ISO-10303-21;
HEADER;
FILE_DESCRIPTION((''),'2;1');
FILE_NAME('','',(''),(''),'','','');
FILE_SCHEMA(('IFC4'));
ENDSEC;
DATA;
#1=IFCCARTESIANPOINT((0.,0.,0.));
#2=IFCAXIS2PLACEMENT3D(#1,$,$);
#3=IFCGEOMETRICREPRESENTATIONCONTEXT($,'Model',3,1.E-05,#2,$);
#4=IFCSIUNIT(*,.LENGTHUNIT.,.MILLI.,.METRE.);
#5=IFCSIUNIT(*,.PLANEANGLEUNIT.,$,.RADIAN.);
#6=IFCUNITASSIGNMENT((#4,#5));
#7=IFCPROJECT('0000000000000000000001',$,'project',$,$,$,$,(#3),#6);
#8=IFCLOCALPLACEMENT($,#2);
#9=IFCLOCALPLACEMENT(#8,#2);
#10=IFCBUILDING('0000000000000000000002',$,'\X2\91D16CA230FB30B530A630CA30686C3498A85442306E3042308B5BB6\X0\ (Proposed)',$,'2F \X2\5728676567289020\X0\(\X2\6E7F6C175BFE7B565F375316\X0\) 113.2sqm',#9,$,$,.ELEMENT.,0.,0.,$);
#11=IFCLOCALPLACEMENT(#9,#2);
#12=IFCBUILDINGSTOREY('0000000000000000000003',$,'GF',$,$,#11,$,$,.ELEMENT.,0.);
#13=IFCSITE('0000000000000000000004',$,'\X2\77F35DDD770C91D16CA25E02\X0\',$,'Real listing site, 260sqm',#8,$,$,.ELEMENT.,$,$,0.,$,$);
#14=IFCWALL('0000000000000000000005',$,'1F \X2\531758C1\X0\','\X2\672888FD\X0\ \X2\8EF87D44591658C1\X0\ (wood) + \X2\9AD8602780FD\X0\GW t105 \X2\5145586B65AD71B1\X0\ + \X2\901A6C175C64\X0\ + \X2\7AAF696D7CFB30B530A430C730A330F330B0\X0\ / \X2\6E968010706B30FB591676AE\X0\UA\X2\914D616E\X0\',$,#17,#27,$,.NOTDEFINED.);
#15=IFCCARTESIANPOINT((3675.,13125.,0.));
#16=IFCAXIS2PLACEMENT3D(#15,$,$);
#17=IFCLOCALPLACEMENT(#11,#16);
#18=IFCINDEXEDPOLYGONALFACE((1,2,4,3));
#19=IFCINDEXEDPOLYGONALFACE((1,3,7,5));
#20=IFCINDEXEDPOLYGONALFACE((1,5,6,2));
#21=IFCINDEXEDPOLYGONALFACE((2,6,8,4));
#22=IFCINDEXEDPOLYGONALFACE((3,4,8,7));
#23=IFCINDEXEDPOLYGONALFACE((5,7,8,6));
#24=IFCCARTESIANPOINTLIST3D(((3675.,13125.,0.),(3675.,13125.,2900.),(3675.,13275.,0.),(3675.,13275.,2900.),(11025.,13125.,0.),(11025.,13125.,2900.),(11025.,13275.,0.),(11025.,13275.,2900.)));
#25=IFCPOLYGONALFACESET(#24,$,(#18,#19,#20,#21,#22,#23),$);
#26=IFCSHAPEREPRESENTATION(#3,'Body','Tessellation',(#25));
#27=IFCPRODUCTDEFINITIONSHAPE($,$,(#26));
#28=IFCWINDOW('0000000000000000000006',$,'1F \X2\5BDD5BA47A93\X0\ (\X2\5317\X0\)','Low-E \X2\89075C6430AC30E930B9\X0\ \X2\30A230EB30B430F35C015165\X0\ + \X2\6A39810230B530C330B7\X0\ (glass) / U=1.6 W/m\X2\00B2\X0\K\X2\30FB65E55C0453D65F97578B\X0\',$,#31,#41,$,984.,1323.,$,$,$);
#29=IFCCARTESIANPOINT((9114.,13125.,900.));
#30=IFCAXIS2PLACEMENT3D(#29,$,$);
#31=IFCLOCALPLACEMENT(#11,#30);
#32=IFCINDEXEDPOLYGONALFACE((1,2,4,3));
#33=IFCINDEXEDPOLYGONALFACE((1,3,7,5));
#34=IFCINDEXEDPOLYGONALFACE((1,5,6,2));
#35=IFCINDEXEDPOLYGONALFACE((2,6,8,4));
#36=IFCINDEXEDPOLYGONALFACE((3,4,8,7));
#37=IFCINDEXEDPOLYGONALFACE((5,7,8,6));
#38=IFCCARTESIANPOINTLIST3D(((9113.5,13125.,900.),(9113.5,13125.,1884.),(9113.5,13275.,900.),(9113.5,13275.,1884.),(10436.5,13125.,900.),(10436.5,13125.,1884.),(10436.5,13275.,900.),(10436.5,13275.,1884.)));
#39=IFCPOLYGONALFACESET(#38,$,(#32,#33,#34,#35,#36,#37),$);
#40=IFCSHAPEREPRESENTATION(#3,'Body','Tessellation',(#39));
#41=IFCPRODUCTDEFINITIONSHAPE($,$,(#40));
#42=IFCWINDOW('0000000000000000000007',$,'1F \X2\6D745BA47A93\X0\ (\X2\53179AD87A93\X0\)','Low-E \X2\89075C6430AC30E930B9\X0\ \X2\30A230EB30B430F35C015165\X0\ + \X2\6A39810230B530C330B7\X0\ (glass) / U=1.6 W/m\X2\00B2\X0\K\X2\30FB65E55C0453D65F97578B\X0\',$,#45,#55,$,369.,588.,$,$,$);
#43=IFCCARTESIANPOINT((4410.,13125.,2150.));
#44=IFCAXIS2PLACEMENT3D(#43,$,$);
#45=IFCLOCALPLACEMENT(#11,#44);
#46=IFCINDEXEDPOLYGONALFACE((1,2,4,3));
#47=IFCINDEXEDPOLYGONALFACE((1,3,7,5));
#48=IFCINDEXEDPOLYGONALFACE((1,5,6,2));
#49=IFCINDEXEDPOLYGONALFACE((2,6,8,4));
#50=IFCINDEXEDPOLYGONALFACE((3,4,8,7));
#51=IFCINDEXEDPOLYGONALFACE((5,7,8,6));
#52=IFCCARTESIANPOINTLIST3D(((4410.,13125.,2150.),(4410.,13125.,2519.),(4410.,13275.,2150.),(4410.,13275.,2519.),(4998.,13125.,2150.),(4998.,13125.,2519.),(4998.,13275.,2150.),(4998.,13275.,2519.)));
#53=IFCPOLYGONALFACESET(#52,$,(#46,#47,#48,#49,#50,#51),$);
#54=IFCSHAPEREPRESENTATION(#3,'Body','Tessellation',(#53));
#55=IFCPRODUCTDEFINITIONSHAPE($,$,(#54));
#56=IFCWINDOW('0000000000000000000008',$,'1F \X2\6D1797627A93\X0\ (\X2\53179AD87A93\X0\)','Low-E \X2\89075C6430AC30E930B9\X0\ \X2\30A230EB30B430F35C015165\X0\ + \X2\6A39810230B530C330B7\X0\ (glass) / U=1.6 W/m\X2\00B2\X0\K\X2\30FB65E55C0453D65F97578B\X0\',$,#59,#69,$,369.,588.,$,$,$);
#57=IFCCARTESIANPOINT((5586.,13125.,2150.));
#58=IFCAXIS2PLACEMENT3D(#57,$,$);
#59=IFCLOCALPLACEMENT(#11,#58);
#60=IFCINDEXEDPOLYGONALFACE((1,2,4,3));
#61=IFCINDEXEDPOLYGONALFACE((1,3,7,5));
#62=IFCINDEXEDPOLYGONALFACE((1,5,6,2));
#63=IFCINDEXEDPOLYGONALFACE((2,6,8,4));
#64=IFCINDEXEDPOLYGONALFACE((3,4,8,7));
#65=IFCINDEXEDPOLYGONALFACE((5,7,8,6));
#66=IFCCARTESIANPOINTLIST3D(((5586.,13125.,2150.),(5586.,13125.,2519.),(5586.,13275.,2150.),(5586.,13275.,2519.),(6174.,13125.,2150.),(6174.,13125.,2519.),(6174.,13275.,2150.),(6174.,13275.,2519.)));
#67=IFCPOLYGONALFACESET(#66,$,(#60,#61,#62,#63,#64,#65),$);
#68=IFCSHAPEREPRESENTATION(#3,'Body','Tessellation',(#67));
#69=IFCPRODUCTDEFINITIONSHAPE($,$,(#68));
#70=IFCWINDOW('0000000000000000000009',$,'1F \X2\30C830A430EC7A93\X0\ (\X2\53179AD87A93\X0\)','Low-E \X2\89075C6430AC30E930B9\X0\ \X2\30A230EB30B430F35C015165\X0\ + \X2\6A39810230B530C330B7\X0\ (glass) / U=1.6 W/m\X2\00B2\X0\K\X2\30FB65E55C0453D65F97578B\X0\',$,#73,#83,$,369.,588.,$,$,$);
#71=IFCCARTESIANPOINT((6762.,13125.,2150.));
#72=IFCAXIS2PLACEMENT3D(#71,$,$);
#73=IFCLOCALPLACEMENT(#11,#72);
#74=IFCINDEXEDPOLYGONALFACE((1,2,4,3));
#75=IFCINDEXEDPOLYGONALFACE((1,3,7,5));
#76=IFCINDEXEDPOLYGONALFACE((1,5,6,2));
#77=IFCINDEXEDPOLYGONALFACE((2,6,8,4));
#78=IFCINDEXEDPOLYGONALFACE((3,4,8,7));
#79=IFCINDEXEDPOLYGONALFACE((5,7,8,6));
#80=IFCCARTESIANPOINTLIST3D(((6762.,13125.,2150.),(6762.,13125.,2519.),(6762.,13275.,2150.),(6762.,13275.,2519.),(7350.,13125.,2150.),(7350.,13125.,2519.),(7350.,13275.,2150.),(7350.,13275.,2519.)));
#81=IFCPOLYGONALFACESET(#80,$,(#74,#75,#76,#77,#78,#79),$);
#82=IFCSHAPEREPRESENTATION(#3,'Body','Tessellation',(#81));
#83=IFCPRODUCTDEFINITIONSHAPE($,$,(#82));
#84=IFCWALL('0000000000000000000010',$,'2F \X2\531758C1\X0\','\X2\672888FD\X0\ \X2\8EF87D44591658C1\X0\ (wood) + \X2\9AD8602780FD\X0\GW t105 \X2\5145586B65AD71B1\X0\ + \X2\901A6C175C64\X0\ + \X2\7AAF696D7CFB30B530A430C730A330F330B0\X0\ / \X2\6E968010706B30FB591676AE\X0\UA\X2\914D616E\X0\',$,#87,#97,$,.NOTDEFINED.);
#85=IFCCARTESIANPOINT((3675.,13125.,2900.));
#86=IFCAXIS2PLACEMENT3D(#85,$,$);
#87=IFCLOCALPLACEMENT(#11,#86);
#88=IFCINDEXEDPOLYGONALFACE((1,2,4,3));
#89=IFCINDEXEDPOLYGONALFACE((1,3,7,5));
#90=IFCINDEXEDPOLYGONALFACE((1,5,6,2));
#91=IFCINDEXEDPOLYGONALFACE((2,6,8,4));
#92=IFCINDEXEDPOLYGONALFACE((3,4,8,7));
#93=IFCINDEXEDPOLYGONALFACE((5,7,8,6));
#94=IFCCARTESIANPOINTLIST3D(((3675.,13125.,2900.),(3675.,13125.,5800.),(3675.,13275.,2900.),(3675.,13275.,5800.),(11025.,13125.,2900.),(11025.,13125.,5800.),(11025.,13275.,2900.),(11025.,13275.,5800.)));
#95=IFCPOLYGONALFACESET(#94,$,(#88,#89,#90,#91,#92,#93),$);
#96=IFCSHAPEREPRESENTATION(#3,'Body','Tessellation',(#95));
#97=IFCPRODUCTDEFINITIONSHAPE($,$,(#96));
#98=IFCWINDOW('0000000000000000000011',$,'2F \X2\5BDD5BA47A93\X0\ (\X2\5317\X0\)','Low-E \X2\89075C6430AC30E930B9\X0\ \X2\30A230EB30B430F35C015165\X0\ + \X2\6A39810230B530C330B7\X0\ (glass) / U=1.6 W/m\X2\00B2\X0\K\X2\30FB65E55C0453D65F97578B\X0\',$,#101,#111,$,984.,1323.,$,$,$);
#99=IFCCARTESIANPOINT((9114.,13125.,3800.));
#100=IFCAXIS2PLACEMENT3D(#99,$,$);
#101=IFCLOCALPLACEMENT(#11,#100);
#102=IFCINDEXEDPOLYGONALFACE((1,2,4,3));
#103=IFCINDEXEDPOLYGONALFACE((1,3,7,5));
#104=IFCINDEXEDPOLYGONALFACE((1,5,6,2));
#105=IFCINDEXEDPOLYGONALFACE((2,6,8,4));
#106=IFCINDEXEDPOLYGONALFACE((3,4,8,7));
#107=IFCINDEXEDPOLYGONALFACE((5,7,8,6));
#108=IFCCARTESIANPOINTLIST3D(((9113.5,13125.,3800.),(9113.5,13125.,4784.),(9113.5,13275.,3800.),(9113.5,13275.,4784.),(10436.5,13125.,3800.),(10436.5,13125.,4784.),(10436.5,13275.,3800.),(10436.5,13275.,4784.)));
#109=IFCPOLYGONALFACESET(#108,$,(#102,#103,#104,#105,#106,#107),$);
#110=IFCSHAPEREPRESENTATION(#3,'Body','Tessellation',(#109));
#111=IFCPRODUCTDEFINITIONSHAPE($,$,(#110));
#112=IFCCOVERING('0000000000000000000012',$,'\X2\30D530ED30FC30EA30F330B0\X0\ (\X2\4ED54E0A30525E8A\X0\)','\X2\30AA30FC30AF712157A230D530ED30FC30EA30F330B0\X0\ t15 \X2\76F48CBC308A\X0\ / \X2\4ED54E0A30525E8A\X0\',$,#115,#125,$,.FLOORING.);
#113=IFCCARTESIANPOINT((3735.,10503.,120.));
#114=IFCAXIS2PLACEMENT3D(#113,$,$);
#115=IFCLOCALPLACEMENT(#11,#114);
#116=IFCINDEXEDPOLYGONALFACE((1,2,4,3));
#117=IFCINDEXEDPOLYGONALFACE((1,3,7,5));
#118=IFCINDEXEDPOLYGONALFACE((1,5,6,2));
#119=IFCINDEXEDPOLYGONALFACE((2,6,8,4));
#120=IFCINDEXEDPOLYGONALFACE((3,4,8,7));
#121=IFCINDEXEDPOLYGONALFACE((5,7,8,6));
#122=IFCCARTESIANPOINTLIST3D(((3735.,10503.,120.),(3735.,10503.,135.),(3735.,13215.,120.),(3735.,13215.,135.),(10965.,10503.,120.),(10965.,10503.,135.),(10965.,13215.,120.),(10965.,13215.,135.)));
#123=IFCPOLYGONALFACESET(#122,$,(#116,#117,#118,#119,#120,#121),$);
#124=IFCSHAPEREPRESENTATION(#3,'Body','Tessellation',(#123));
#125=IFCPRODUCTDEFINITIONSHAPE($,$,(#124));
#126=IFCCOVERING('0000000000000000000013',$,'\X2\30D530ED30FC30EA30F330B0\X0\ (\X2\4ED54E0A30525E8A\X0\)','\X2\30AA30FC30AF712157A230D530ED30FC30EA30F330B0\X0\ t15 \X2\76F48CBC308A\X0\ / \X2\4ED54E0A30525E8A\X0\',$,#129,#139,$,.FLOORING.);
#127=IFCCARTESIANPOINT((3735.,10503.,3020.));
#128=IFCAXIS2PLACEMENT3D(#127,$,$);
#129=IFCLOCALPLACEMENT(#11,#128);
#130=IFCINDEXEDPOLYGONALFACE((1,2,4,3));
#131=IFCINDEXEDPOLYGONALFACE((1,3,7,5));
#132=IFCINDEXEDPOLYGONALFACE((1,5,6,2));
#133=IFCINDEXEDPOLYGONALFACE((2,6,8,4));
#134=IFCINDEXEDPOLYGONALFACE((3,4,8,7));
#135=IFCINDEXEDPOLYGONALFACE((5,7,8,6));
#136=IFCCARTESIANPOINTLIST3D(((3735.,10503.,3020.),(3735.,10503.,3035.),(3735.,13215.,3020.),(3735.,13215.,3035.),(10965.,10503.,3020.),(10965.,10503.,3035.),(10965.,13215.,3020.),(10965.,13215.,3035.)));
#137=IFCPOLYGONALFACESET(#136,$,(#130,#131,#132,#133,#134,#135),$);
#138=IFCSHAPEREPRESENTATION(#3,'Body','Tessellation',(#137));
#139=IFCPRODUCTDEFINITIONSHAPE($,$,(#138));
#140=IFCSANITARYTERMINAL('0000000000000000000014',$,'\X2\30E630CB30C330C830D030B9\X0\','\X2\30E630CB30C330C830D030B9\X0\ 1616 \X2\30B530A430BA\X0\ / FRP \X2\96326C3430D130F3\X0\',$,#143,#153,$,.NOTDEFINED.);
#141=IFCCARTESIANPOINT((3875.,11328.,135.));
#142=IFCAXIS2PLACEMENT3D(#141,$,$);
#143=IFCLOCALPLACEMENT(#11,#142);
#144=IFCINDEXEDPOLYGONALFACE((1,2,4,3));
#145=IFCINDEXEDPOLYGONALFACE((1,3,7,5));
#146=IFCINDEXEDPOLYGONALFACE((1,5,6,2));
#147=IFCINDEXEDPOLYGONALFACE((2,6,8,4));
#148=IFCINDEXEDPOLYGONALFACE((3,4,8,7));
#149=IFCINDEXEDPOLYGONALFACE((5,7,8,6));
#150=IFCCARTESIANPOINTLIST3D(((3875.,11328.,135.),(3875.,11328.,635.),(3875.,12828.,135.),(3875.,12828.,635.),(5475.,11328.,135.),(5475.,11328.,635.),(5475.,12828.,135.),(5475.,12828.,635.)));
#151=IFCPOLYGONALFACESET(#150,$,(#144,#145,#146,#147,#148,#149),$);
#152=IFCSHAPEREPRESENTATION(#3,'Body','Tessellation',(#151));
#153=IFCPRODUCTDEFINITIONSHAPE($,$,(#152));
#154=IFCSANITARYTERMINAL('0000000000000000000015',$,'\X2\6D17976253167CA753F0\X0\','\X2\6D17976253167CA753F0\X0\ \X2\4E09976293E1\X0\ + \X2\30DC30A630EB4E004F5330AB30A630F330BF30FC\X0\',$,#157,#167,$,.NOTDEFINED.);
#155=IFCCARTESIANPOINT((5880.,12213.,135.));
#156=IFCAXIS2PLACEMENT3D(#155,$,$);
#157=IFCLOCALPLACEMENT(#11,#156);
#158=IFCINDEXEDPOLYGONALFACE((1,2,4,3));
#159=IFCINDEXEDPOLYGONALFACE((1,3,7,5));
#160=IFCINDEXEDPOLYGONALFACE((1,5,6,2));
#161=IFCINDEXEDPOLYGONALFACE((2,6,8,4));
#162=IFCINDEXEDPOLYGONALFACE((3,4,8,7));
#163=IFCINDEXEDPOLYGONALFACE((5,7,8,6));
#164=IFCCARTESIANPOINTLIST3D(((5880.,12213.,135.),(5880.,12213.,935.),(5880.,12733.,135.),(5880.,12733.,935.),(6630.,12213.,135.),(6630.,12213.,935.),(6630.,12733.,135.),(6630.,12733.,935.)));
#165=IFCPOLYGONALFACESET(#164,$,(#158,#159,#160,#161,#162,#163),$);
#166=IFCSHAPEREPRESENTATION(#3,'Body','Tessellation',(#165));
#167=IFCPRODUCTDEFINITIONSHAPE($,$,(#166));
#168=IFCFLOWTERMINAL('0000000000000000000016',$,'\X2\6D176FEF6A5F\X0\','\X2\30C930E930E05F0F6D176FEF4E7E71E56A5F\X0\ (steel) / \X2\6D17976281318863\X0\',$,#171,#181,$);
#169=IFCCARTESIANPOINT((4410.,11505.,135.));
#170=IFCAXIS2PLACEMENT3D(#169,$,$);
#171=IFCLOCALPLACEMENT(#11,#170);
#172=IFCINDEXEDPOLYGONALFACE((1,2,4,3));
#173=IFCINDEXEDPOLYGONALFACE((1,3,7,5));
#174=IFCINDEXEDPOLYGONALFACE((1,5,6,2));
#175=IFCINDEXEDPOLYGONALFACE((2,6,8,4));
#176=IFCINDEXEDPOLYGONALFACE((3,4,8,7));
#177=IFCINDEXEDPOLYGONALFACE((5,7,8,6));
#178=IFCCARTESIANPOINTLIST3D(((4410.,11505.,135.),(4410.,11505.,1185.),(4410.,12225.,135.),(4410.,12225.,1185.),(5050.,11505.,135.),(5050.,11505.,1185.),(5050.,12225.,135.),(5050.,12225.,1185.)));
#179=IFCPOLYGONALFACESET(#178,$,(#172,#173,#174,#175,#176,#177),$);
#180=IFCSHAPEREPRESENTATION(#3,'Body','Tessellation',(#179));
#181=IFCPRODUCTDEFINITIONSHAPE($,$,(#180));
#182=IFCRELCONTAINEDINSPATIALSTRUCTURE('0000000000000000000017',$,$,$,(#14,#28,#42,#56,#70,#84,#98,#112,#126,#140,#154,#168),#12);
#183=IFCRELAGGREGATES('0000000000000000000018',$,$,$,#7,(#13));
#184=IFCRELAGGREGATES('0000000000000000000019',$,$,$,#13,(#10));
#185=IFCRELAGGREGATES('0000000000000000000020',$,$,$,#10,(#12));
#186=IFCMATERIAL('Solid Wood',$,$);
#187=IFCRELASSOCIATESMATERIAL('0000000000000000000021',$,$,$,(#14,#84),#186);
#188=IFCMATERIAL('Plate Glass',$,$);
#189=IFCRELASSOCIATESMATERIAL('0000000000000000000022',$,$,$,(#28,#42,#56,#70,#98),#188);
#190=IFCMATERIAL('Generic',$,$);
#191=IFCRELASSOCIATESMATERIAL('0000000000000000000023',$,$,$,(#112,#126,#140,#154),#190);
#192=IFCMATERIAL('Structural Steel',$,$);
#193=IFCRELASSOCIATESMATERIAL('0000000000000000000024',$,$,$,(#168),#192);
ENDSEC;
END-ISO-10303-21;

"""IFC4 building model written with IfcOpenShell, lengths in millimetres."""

from ifc_helpers import new_model, si_unit, frame, frame_2d, origin, place, context, project, spatial, rectangle, extrude, material, element, fill, save


model = new_model("IFC4")

# Units and contexts
model_context = context("Model", 3, precision=1e-05, world=origin())
ifc_project = project(units=[si_unit("LENGTHUNIT", "METRE", prefix="MILLI"), si_unit("PLANEANGLEUNIT", "RADIAN")], contexts=[model_context])

# Site, building, storey
site_placement = place(None, origin())
site = spatial("IfcSite", under=ifc_project, at=site_placement, Name="石川県金沢市", ObjectType="Real listing site, 260sqm", CompositionType="ELEMENT", RefElevation=0.0)
building_placement = place(site_placement, origin())
building = spatial("IfcBuilding", under=site, at=building_placement, Name="金沢・サウナと水風呂のある家 (Proposed)", ObjectType="2F 在来木造(湿気対策強化) 113.2sqm", CompositionType="ELEMENT", ElevationOfRefHeight=0.0, ElevationOfTerrain=0.0)
storey_placement = place(building_placement, origin())
storey = spatial("IfcBuildingStorey", under=building, at=storey_placement, Name="GF", CompositionType="ELEMENT", Elevation=0.0)

# Shared definitions
ifc_material_1 = material(Name="Solid Wood")

# Wall, openings, windows
wall_1_placement = place(storey_placement, frame((3675.0, 13125.0, 0.0)))
wall_1 = element("IfcWall", 1, at=wall_1_placement, inside=storey, material=ifc_material_1, Name="1F 北壁", Description="木製 軸組外壁 (wood) + 高性能GW t105 充填断熱 + 通気層 + 窯業系サイディング / 準耐火・外皮UA配慮", PredefinedType="NOTDEFINED", context=model_context, shape_type="SweptSolid", body=[
    extrude(rectangle(XDim=7350.0, YDim=150.0, at=frame_2d((3675.0, 75.0))), frame((3675.0, 13125.0, 0.0)), (0.0, 0.0, 1.0), 2900.0),
])
opening_1_placement = place(storey_placement, frame((9114.0, 13125.0, 900.0)))
opening_1 = element("IfcOpeningElement", 2, at=opening_1_placement, cuts=wall_1, PredefinedType="NOTDEFINED", context=model_context, shape_type="SweptSolid", body=[
    extrude(rectangle(XDim=1323.0, YDim=150.0, at=frame_2d((661.0, 75.0))), frame((9114.0, 13125.0, 900.0)), (0.0, 0.0, 1.0), 984.0),
])
opening_2_placement = place(storey_placement, frame((4410.0, 13125.0, 2150.0)))
opening_2 = element("IfcOpeningElement", 3, at=opening_2_placement, cuts=wall_1, PredefinedType="NOTDEFINED", context=model_context, shape_type="SweptSolid", body=[
    extrude(rectangle(XDim=588.0, YDim=150.0, at=frame_2d((294.0, 75.0))), frame((4410.0, 13125.0, 2150.0)), (0.0, 0.0, 1.0), 369.0),
])
opening_3_placement = place(storey_placement, frame((5586.0, 13125.0, 2150.0)))
opening_3 = element("IfcOpeningElement", 4, at=opening_3_placement, cuts=wall_1, PredefinedType="NOTDEFINED", context=model_context, shape_type="SweptSolid", body=[
    extrude(rectangle(XDim=588.0, YDim=150.0, at=frame_2d((294.0, 75.0))), frame((5586.0, 13125.0, 2150.0)), (0.0, 0.0, 1.0), 369.0),
])
opening_4_placement = place(storey_placement, frame((6762.0, 13125.0, 2150.0)))
opening_4 = element("IfcOpeningElement", 5, at=opening_4_placement, cuts=wall_1, PredefinedType="NOTDEFINED", context=model_context, shape_type="SweptSolid", body=[
    extrude(rectangle(XDim=588.0, YDim=150.0, at=frame_2d((294.0, 75.0))), frame((6762.0, 13125.0, 2150.0)), (0.0, 0.0, 1.0), 369.0),
])
ifc_material_2 = material(Name="Plate Glass")
window_1_placement = place(storey_placement, frame((9114.0, 13125.0, 900.0)))
window_1 = element("IfcWindow", 6, at=window_1_placement, inside=storey, material=ifc_material_2, Name="1F 寝室窓 (北)", Description="Low-E 複層ガラス アルゴン封入 + 樹脂サッシ (glass) / U=1.6 W/m²K・日射取得型", OverallHeight=984.0, OverallWidth=1323.0, context=model_context, shape_type="SweptSolid", body=[
    extrude(rectangle(XDim=1323.0, YDim=150.0, at=frame_2d((661.0, 75.0))), frame((9114.0, 13125.0, 900.0)), (0.0, 0.0, 1.0), 984.0),
])
fill(opening_1, window_1)
window_2_placement = place(storey_placement, frame((4410.0, 13125.0, 2150.0)))
window_2 = element("IfcWindow", 7, at=window_2_placement, inside=storey, material=ifc_material_2, Name="1F 浴室窓 (北高窓)", Description="Low-E 複層ガラス アルゴン封入 + 樹脂サッシ (glass) / U=1.6 W/m²K・日射取得型", OverallHeight=369.0, OverallWidth=588.0, context=model_context, shape_type="SweptSolid", body=[
    extrude(rectangle(XDim=588.0, YDim=150.0, at=frame_2d((294.0, 75.0))), frame((4410.0, 13125.0, 2150.0)), (0.0, 0.0, 1.0), 369.0),
])
fill(opening_2, window_2)
window_3_placement = place(storey_placement, frame((5586.0, 13125.0, 2150.0)))
window_3 = element("IfcWindow", 8, at=window_3_placement, inside=storey, material=ifc_material_2, Name="1F 洗面窓 (北高窓)", Description="Low-E 複層ガラス アルゴン封入 + 樹脂サッシ (glass) / U=1.6 W/m²K・日射取得型", OverallHeight=369.0, OverallWidth=588.0, context=model_context, shape_type="SweptSolid", body=[
    extrude(rectangle(XDim=588.0, YDim=150.0, at=frame_2d((294.0, 75.0))), frame((5586.0, 13125.0, 2150.0)), (0.0, 0.0, 1.0), 369.0),
])
fill(opening_3, window_3)
window_4_placement = place(storey_placement, frame((6762.0, 13125.0, 2150.0)))
window_4 = element("IfcWindow", 9, at=window_4_placement, inside=storey, material=ifc_material_2, Name="1F トイレ窓 (北高窓)", Description="Low-E 複層ガラス アルゴン封入 + 樹脂サッシ (glass) / U=1.6 W/m²K・日射取得型", OverallHeight=369.0, OverallWidth=588.0, context=model_context, shape_type="SweptSolid", body=[
    extrude(rectangle(XDim=588.0, YDim=150.0, at=frame_2d((294.0, 75.0))), frame((6762.0, 13125.0, 2150.0)), (0.0, 0.0, 1.0), 369.0),
])
fill(opening_4, window_4)

# Wall, opening, window
wall_2_placement = place(storey_placement, frame((3675.0, 13125.0, 2900.0)))
wall_2 = element("IfcWall", 10, at=wall_2_placement, inside=storey, material=ifc_material_1, Name="2F 北壁", Description="木製 軸組外壁 (wood) + 高性能GW t105 充填断熱 + 通気層 + 窯業系サイディング / 準耐火・外皮UA配慮", PredefinedType="NOTDEFINED", context=model_context, shape_type="SweptSolid", body=[
    extrude(rectangle(XDim=7350.0, YDim=150.0, at=frame_2d((3675.0, 75.0))), frame((3675.0, 13125.0, 2900.0)), (0.0, 0.0, 1.0), 2900.0),
])
opening_5_placement = place(storey_placement, frame((9114.0, 13125.0, 3800.0)))
opening_5 = element("IfcOpeningElement", 11, at=opening_5_placement, cuts=wall_2, PredefinedType="NOTDEFINED", context=model_context, shape_type="SweptSolid", body=[
    extrude(rectangle(XDim=1323.0, YDim=150.0, at=frame_2d((661.0, 75.0))), frame((9114.0, 13125.0, 3800.0)), (0.0, 0.0, 1.0), 984.0),
])
window_5_placement = place(storey_placement, frame((9114.0, 13125.0, 3800.0)))
window_5 = element("IfcWindow", 12, at=window_5_placement, inside=storey, material=ifc_material_2, Name="2F 寝室窓 (北)", Description="Low-E 複層ガラス アルゴン封入 + 樹脂サッシ (glass) / U=1.6 W/m²K・日射取得型", OverallHeight=984.0, OverallWidth=1323.0, context=model_context, shape_type="SweptSolid", body=[
    extrude(rectangle(XDim=1323.0, YDim=150.0, at=frame_2d((661.0, 75.0))), frame((9114.0, 13125.0, 3800.0)), (0.0, 0.0, 1.0), 984.0),
])
fill(opening_5, window_5)

# Coverings
ifc_material_3 = material(Name="Generic")
covering_1_placement = place(storey_placement, frame((3735.0, 10503.0, 120.0)))
element("IfcCovering", 13, at=covering_1_placement, inside=storey, material=ifc_material_3, Name="フローリング (仕上げ床)", Description="オーク無垢フローリング t15 直貼り / 仕上げ床", PredefinedType="FLOORING", context=model_context, shape_type="SweptSolid", body=[
    extrude(rectangle(XDim=7230.0, YDim=2712.0, at=frame_2d((3615.0, 1356.0))), frame((3735.0, 10503.0, 120.0)), (0.0, 0.0, 1.0), 15.0),
])
covering_2_placement = place(storey_placement, frame((3735.0, 10503.0, 3020.0)))
element("IfcCovering", 14, at=covering_2_placement, inside=storey, material=ifc_material_3, Name="フローリング (仕上げ床)", Description="オーク無垢フローリング t15 直貼り / 仕上げ床", PredefinedType="FLOORING", context=model_context, shape_type="SweptSolid", body=[
    extrude(rectangle(XDim=7230.0, YDim=2712.0, at=frame_2d((3615.0, 1356.0))), frame((3735.0, 10503.0, 3020.0)), (0.0, 0.0, 1.0), 15.0),
])

# Sanitary terminals
sanitary_terminal_1_placement = place(storey_placement, frame((3875.0, 11328.0, 135.0)))
element("IfcSanitaryTerminal", 15, at=sanitary_terminal_1_placement, inside=storey, material=ifc_material_3, Name="ユニットバス", Description="ユニットバス 1616 サイズ / FRP 防水パン", PredefinedType="NOTDEFINED", context=model_context, shape_type="SweptSolid", body=[
    extrude(rectangle(XDim=1600.0, YDim=1500.0, at=frame_2d((800.0, 750.0))), frame((3875.0, 11328.0, 135.0)), (0.0, 0.0, 1.0), 500.0),
])
sanitary_terminal_2_placement = place(storey_placement, frame((5880.0, 12213.0, 135.0)))
element("IfcSanitaryTerminal", 16, at=sanitary_terminal_2_placement, inside=storey, material=ifc_material_3, Name="洗面化粧台", Description="洗面化粧台 三面鏡 + ボウル一体カウンター", PredefinedType="NOTDEFINED", context=model_context, shape_type="SweptSolid", body=[
    extrude(rectangle(XDim=750.0, YDim=520.0, at=frame_2d((375.0, 260.0))), frame((5880.0, 12213.0, 135.0)), (0.0, 0.0, 1.0), 800.0),
])

# Flow terminal
ifc_material_4 = material(Name="Structural Steel")
flow_terminal_placement = place(storey_placement, frame((4410.0, 11505.0, 135.0)))
element("IfcFlowTerminal", 17, at=flow_terminal_placement, inside=storey, material=ifc_material_4, Name="洗濯機", Description="ドラム式洗濯乾燥機 (steel) / 洗面脱衣", context=model_context, shape_type="SweptSolid", body=[
    extrude(rectangle(XDim=640.0, YDim=720.0, at=frame_2d((320.0, 360.0))), frame((4410.0, 11505.0, 135.0)), (0.0, 0.0, 1.0), 1050.0),
])

save(model, "model.ifc")
